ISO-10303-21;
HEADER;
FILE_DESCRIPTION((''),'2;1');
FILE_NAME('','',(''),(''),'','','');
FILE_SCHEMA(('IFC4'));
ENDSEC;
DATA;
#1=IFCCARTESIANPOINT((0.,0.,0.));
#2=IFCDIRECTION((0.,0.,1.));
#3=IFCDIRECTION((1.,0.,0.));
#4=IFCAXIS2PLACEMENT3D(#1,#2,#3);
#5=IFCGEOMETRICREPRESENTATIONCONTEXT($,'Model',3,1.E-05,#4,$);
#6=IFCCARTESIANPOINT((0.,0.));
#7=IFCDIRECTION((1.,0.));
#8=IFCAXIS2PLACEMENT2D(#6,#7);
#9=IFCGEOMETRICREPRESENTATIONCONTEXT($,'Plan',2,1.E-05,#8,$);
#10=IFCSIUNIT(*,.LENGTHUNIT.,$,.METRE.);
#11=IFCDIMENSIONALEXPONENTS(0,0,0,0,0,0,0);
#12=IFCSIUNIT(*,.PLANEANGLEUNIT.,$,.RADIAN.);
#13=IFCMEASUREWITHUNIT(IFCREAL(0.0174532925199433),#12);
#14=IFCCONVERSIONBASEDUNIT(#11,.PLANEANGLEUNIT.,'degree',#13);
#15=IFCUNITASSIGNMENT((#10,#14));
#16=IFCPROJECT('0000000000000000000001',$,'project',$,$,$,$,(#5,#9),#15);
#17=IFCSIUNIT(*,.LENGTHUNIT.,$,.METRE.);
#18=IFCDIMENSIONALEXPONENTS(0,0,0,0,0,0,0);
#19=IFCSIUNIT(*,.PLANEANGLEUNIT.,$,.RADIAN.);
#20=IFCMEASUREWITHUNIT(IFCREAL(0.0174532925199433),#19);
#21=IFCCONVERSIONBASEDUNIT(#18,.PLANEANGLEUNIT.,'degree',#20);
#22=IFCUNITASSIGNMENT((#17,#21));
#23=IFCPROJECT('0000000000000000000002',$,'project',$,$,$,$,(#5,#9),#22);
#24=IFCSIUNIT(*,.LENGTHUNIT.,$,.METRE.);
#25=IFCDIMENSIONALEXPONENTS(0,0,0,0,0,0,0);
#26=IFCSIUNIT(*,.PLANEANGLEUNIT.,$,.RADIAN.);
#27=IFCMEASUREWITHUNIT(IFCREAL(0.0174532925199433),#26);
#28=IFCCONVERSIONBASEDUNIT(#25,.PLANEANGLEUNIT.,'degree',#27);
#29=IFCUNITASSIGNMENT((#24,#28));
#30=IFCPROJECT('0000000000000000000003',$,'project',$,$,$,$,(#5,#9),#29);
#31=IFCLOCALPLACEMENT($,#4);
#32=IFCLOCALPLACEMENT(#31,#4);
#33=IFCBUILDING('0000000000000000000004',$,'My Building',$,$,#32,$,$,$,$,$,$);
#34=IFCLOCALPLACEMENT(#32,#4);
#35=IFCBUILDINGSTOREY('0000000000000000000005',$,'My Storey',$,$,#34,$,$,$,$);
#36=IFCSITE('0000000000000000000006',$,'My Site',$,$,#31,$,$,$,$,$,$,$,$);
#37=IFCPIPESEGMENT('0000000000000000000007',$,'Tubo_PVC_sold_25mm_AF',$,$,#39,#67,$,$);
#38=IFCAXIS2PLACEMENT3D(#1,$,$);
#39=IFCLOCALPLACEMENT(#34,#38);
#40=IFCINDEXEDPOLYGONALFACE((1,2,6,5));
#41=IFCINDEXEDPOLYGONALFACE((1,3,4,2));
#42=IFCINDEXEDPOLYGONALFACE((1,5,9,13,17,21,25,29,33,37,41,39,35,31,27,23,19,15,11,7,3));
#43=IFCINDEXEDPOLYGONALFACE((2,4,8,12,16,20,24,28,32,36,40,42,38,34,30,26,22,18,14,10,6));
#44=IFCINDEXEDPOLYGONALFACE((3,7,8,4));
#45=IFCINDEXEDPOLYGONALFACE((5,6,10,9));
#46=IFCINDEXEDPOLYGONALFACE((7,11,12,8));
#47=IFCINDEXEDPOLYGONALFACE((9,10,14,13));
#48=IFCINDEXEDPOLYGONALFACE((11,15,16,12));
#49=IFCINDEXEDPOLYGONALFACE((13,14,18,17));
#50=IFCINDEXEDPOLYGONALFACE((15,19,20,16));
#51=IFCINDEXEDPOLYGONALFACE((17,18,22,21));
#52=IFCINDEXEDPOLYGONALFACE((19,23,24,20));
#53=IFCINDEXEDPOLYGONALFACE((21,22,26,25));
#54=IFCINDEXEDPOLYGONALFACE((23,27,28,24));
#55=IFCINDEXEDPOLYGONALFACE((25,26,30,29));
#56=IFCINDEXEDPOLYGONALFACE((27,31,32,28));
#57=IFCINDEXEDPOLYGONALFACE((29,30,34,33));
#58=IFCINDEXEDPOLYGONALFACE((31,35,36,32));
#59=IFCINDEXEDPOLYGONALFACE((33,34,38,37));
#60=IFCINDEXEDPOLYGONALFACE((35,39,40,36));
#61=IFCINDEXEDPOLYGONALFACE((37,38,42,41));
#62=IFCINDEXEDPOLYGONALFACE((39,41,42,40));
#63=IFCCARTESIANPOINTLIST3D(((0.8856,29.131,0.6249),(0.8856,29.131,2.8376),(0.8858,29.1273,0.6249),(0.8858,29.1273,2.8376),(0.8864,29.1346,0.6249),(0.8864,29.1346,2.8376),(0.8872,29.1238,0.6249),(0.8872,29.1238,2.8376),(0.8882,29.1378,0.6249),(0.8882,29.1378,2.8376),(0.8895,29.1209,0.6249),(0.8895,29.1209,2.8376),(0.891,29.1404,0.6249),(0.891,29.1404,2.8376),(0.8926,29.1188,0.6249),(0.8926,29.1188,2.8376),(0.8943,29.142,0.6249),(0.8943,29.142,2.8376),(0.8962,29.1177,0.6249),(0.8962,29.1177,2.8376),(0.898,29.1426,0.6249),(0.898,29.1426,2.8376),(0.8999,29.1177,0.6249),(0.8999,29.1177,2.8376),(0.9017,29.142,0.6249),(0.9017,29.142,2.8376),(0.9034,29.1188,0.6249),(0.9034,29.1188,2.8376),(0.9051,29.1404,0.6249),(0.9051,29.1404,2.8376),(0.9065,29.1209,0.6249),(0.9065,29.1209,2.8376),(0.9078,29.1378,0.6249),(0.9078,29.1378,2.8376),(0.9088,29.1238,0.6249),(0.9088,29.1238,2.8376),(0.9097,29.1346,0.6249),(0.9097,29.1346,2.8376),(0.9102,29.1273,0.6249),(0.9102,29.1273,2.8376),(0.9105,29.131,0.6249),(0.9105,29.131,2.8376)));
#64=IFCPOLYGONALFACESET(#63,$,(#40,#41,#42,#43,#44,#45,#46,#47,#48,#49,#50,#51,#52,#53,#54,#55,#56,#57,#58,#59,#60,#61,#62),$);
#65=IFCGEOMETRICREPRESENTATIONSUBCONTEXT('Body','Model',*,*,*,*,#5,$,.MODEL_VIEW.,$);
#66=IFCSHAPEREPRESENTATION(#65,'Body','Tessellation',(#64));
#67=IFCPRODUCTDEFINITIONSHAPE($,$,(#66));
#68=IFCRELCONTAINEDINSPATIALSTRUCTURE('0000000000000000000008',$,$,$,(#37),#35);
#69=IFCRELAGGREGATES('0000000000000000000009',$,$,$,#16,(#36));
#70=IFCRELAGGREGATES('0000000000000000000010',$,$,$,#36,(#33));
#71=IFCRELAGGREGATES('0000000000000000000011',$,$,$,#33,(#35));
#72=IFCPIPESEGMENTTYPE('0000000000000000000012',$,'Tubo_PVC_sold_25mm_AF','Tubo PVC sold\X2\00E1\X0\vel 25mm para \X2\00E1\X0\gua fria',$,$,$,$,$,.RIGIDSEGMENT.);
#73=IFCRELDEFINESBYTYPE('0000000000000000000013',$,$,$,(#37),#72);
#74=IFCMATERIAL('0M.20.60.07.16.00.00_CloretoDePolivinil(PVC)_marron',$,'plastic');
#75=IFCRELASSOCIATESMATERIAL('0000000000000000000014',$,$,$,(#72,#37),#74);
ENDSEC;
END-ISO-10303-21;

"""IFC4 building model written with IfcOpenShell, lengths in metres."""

from ifc_helpers import new_model, entity, si_unit, converted_unit, frame, origin_with_axes, origin_2d_with_axis, place, context, subcontext, project, spatial, circle, extrude, material, material_profile, profile_set, profile_usage, type_object, element, save


model = new_model("IFC4")

# Units and contexts
model_context = context("Model", 3, precision=1e-05, world=origin_with_axes())
plan_context = context("Plan", 2, precision=1e-05, world=origin_2d_with_axis())
body_context_1 = subcontext(model_context, "Body", "Model", "MODEL_VIEW")
ifc_project_1 = project(units=[si_unit("LENGTHUNIT", "METRE"), converted_unit("PLANEANGLEUNIT", "degree", entity("IfcReal", 0.0174532925199433), si_unit("PLANEANGLEUNIT", "RADIAN"), dimensions=[0, 0, 0, 0, 0, 0, 0])], contexts=[model_context, plan_context])
ifc_project_2 = project(units=[si_unit("LENGTHUNIT", "METRE"), converted_unit("PLANEANGLEUNIT", "degree", entity("IfcReal", 0.0174532925199433), si_unit("PLANEANGLEUNIT", "RADIAN"), dimensions=[0, 0, 0, 0, 0, 0, 0])], contexts=[model_context, plan_context])
ifc_project_3 = project(units=[si_unit("LENGTHUNIT", "METRE"), converted_unit("PLANEANGLEUNIT", "degree", entity("IfcReal", 0.0174532925199433), si_unit("PLANEANGLEUNIT", "RADIAN"), dimensions=[0, 0, 0, 0, 0, 0, 0])], contexts=[model_context, plan_context])

# Site, building, storey
site_placement = place(None, origin_with_axes())
site = spatial("IfcSite", under=ifc_project_1, at=site_placement, Name="My Site")
building_placement = place(site_placement, origin_with_axes())
building = spatial("IfcBuilding", under=site, at=building_placement, Name="My Building")
storey_placement = place(building_placement, origin_with_axes())
storey = spatial("IfcBuildingStorey", under=building, at=storey_placement, Name="My Storey")

# Pipe segment
ifc_material_1 = material(Name="0M.20.60.07.16.00.00_CloretoDePolivinil(PVC)_marron", Category="plastic")
ifc_material_profile_1 = material_profile(ifc_material_1, circle(Radius=0.0125))
ifc_profile_set_1 = profile_set([ifc_material_profile_1])
pipe_segment_type_1 = type_object("IfcPipeSegmentType", Name="Tubo_PVC_sold_25mm_AF", Description="Tubo PVC soldável 25mm para água fria", PredefinedType="RIGIDSEGMENT", material=ifc_profile_set_1)
ifc_profile_usage_1 = profile_usage(ifc_profile_set_1, cardinal=5)
pipe_segment_1_placement = place(storey_placement, frame((0.898, 29.1301, 0.6249), z_axis=(0.0, 0.0, 1.0), x_axis=(0.0, 1.0, 0.0)))
element("IfcPipeSegment", 1, at=pipe_segment_1_placement, inside=storey, type_object=pipe_segment_type_1, material=ifc_profile_usage_1, Name="Tubo_PVC_sold_25mm_AF", context=body_context_1, shape_type="SweptSolid", body=[
    extrude(circle(Radius=0.0125), origin_with_axes(), (0.0, 0.0, 1.0), 2.2127),
])

save(model, "model.ifc")
